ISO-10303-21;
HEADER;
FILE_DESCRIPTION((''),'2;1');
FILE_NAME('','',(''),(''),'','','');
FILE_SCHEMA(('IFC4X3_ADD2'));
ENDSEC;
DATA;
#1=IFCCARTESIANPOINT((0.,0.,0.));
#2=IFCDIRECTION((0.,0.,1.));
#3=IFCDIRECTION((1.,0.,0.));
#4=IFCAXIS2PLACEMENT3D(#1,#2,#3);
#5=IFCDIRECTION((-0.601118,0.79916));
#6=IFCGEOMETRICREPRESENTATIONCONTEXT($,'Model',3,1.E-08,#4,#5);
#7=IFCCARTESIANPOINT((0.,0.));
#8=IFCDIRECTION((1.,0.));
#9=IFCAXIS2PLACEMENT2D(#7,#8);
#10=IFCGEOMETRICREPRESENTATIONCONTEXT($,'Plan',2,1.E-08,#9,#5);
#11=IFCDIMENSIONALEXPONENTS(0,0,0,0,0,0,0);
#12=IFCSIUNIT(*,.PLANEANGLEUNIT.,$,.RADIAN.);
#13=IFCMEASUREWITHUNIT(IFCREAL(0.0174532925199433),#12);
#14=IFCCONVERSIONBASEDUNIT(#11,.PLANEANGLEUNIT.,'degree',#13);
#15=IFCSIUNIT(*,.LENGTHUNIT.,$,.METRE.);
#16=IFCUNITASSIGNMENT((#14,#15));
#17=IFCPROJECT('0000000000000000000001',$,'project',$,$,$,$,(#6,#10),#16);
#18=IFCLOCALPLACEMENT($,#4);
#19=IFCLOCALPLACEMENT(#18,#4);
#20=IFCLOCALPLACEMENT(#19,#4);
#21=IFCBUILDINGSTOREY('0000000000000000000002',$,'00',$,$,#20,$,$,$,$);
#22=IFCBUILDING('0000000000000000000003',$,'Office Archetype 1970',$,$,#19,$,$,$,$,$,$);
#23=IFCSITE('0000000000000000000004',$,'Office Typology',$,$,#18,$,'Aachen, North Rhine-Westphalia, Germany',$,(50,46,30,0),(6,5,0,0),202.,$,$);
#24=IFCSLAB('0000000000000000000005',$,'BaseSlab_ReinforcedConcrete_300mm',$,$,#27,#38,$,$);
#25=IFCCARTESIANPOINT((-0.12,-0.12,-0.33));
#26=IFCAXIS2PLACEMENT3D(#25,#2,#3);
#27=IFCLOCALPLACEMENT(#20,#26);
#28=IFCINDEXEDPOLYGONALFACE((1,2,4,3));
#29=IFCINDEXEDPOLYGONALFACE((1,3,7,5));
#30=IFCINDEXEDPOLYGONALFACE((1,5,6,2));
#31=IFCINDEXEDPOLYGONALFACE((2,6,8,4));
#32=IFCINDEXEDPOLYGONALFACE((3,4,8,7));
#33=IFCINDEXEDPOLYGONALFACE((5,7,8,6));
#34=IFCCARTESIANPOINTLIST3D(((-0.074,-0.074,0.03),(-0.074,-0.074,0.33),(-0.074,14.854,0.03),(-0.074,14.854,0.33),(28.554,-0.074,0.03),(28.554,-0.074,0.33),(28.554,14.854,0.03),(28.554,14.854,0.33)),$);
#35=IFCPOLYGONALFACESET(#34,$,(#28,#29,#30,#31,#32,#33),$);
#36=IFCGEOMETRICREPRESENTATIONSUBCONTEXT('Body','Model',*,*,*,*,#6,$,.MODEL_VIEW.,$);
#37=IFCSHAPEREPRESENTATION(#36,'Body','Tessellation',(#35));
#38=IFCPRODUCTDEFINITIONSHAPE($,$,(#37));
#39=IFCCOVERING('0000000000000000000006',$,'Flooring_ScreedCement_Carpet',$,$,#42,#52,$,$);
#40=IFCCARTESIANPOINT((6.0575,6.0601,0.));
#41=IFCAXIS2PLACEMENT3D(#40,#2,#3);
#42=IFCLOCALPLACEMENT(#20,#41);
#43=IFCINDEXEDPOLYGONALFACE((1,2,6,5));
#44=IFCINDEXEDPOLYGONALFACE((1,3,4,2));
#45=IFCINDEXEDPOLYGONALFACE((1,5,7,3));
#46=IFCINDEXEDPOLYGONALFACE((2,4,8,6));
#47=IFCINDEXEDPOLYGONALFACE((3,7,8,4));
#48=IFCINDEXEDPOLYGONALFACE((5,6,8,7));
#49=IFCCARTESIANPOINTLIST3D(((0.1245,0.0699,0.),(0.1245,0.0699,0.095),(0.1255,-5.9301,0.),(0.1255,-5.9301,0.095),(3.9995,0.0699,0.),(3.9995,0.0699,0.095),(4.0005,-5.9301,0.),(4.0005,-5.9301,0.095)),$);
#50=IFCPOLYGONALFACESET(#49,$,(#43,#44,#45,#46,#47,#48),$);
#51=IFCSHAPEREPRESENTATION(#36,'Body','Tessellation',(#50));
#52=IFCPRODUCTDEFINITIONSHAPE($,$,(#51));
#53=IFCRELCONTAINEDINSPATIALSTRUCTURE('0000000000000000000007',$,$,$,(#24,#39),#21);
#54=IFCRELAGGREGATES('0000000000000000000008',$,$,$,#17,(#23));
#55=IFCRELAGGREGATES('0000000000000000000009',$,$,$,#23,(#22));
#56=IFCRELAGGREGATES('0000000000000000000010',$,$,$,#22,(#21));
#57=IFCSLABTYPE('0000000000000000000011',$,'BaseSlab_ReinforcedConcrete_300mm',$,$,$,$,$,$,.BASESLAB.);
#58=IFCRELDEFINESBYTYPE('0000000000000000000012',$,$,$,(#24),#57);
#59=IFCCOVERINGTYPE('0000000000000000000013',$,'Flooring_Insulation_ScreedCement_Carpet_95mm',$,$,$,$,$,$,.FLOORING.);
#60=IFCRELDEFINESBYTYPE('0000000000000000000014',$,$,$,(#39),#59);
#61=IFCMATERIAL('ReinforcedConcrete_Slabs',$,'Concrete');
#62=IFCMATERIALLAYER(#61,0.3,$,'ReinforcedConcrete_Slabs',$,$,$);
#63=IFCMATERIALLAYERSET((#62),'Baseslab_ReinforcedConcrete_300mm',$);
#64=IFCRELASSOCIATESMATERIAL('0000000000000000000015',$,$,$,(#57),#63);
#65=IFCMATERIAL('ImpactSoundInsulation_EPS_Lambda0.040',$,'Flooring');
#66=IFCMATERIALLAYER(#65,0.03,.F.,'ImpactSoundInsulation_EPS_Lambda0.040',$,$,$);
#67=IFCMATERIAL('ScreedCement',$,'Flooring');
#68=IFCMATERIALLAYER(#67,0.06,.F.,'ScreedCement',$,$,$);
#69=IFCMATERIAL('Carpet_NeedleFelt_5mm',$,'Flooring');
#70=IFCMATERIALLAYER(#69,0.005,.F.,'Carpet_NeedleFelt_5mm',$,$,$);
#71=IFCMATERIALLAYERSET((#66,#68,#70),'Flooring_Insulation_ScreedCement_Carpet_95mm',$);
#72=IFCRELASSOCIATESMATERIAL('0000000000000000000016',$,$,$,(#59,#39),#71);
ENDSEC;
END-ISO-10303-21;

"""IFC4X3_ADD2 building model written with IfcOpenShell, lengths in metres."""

from ifc_helpers import new_model, entity, si_unit, converted_unit, direction, frame, origin_with_axes, origin_2d_with_axis, place, context, subcontext, project, spatial, line, indexed_curve, outline, extrude, material, layer, layer_set, layer_usage, type_object, element, save


model = new_model("IFC4X3_ADD2")

# Units and contexts
model_context = context("Model", 3, precision=1e-08, world=origin_with_axes(), true_north=direction((-0.601118, 0.79916)))
plan_context = context("Plan", 2, precision=1e-08, world=origin_2d_with_axis(), true_north=direction((-0.601118, 0.79916)))
body_context = subcontext(model_context, "Body", "Model", "MODEL_VIEW")
ifc_project = project(units=[converted_unit("PLANEANGLEUNIT", "degree", entity("IfcReal", 0.0174532925199433), si_unit("PLANEANGLEUNIT", "RADIAN"), dimensions=[0, 0, 0, 0, 0, 0, 0]), si_unit("LENGTHUNIT", "METRE")], contexts=[model_context, plan_context])

# Site, building, storey
site_placement = place(None, origin_with_axes())
site = spatial("IfcSite", under=ifc_project, at=site_placement, Name="Office Typology", LongName="Aachen, North Rhine-Westphalia, Germany", RefLatitude=(50, 46, 30, 0), RefLongitude=(6, 5, 0, 0), RefElevation=202.0)
building_placement = place(site_placement, origin_with_axes())
building = spatial("IfcBuilding", under=site, at=building_placement, Name="Office Archetype 1970")
storey_placement = place(building_placement, origin_with_axes())
storey = spatial("IfcBuildingStorey", under=building, at=storey_placement, Name="00")

# Slab
ifc_material_1 = material(Name="ReinforcedConcrete_Slabs", Category="Concrete")
ifc_layer_1 = layer(ifc_material_1, 0.3, Name="ReinforcedConcrete_Slabs")
ifc_layer_set_1 = layer_set([ifc_layer_1], Name="Baseslab_ReinforcedConcrete_300mm")
slab_type = type_object("IfcSlabType", Name="BaseSlab_ReinforcedConcrete_300mm", PredefinedType="BASESLAB", material=ifc_layer_set_1)
slab_placement = place(storey_placement, frame((-0.12, -0.12, -0.33), z_axis=(0.0, 0.0, 1.0), x_axis=(1.0, 0.0, 0.0)))
element("IfcSlab", 1, at=slab_placement, inside=storey, type_object=slab_type, Name="BaseSlab_ReinforcedConcrete_300mm", context=body_context, shape_type="SweptSolid", body=[
    extrude(outline(indexed_curve([(-0.074, 14.854), (28.554, 14.854), (28.554, -0.074), (-0.074, -0.074), (-0.074, 14.854)])), frame((0.0, 0.0, 0.03), z_axis=(0.0, 0.0, 1.0), x_axis=(1.0, 0.0, 0.0)), (0.0, 0.0, 1.0), 0.3),
])

# Covering
ifc_material_2 = material(Name="ImpactSoundInsulation_EPS_Lambda0.040", Category="Flooring")
ifc_layer_2 = layer(ifc_material_2, 0.03, ventilated=False, Name="ImpactSoundInsulation_EPS_Lambda0.040")
ifc_material_3 = material(Name="ScreedCement", Category="Flooring")
ifc_layer_3 = layer(ifc_material_3, 0.06, ventilated=False, Name="ScreedCement")
ifc_material_4 = material(Name="Carpet_NeedleFelt_5mm", Category="Flooring")
ifc_layer_4 = layer(ifc_material_4, 0.005, ventilated=False, Name="Carpet_NeedleFelt_5mm")
ifc_layer_set_2 = layer_set([ifc_layer_2, ifc_layer_3, ifc_layer_4], Name="Flooring_Insulation_ScreedCement_Carpet_95mm")
ifc_layer_usage_1 = layer_usage(ifc_layer_set_2, "AXIS3", "POSITIVE", 0.0)
covering_type = type_object("IfcCoveringType", Name="Flooring_Insulation_ScreedCement_Carpet_95mm", PredefinedType="FLOORING", material=ifc_layer_set_2)
covering_placement = place(storey_placement, frame((6.0575, 6.0601, 0.0), z_axis=(0.0, 0.0, 1.0), x_axis=(1.0, 0.0, 0.0)))
element("IfcCovering", 2, at=covering_placement, inside=storey, type_object=covering_type, material=ifc_layer_usage_1, Name="Flooring_ScreedCement_Carpet", context=body_context, shape_type="SweptSolid", body=[
    extrude(outline(indexed_curve([(0.1255, -5.9301), (0.1245, 0.0699), (3.9995, 0.0699), (4.0005, -5.9301)], segments=[line(1, 2, 3, 4, 1)])), origin_with_axes(), (0.0, 0.0, 1.0), 0.095),
])

save(model, "model.ifc")
